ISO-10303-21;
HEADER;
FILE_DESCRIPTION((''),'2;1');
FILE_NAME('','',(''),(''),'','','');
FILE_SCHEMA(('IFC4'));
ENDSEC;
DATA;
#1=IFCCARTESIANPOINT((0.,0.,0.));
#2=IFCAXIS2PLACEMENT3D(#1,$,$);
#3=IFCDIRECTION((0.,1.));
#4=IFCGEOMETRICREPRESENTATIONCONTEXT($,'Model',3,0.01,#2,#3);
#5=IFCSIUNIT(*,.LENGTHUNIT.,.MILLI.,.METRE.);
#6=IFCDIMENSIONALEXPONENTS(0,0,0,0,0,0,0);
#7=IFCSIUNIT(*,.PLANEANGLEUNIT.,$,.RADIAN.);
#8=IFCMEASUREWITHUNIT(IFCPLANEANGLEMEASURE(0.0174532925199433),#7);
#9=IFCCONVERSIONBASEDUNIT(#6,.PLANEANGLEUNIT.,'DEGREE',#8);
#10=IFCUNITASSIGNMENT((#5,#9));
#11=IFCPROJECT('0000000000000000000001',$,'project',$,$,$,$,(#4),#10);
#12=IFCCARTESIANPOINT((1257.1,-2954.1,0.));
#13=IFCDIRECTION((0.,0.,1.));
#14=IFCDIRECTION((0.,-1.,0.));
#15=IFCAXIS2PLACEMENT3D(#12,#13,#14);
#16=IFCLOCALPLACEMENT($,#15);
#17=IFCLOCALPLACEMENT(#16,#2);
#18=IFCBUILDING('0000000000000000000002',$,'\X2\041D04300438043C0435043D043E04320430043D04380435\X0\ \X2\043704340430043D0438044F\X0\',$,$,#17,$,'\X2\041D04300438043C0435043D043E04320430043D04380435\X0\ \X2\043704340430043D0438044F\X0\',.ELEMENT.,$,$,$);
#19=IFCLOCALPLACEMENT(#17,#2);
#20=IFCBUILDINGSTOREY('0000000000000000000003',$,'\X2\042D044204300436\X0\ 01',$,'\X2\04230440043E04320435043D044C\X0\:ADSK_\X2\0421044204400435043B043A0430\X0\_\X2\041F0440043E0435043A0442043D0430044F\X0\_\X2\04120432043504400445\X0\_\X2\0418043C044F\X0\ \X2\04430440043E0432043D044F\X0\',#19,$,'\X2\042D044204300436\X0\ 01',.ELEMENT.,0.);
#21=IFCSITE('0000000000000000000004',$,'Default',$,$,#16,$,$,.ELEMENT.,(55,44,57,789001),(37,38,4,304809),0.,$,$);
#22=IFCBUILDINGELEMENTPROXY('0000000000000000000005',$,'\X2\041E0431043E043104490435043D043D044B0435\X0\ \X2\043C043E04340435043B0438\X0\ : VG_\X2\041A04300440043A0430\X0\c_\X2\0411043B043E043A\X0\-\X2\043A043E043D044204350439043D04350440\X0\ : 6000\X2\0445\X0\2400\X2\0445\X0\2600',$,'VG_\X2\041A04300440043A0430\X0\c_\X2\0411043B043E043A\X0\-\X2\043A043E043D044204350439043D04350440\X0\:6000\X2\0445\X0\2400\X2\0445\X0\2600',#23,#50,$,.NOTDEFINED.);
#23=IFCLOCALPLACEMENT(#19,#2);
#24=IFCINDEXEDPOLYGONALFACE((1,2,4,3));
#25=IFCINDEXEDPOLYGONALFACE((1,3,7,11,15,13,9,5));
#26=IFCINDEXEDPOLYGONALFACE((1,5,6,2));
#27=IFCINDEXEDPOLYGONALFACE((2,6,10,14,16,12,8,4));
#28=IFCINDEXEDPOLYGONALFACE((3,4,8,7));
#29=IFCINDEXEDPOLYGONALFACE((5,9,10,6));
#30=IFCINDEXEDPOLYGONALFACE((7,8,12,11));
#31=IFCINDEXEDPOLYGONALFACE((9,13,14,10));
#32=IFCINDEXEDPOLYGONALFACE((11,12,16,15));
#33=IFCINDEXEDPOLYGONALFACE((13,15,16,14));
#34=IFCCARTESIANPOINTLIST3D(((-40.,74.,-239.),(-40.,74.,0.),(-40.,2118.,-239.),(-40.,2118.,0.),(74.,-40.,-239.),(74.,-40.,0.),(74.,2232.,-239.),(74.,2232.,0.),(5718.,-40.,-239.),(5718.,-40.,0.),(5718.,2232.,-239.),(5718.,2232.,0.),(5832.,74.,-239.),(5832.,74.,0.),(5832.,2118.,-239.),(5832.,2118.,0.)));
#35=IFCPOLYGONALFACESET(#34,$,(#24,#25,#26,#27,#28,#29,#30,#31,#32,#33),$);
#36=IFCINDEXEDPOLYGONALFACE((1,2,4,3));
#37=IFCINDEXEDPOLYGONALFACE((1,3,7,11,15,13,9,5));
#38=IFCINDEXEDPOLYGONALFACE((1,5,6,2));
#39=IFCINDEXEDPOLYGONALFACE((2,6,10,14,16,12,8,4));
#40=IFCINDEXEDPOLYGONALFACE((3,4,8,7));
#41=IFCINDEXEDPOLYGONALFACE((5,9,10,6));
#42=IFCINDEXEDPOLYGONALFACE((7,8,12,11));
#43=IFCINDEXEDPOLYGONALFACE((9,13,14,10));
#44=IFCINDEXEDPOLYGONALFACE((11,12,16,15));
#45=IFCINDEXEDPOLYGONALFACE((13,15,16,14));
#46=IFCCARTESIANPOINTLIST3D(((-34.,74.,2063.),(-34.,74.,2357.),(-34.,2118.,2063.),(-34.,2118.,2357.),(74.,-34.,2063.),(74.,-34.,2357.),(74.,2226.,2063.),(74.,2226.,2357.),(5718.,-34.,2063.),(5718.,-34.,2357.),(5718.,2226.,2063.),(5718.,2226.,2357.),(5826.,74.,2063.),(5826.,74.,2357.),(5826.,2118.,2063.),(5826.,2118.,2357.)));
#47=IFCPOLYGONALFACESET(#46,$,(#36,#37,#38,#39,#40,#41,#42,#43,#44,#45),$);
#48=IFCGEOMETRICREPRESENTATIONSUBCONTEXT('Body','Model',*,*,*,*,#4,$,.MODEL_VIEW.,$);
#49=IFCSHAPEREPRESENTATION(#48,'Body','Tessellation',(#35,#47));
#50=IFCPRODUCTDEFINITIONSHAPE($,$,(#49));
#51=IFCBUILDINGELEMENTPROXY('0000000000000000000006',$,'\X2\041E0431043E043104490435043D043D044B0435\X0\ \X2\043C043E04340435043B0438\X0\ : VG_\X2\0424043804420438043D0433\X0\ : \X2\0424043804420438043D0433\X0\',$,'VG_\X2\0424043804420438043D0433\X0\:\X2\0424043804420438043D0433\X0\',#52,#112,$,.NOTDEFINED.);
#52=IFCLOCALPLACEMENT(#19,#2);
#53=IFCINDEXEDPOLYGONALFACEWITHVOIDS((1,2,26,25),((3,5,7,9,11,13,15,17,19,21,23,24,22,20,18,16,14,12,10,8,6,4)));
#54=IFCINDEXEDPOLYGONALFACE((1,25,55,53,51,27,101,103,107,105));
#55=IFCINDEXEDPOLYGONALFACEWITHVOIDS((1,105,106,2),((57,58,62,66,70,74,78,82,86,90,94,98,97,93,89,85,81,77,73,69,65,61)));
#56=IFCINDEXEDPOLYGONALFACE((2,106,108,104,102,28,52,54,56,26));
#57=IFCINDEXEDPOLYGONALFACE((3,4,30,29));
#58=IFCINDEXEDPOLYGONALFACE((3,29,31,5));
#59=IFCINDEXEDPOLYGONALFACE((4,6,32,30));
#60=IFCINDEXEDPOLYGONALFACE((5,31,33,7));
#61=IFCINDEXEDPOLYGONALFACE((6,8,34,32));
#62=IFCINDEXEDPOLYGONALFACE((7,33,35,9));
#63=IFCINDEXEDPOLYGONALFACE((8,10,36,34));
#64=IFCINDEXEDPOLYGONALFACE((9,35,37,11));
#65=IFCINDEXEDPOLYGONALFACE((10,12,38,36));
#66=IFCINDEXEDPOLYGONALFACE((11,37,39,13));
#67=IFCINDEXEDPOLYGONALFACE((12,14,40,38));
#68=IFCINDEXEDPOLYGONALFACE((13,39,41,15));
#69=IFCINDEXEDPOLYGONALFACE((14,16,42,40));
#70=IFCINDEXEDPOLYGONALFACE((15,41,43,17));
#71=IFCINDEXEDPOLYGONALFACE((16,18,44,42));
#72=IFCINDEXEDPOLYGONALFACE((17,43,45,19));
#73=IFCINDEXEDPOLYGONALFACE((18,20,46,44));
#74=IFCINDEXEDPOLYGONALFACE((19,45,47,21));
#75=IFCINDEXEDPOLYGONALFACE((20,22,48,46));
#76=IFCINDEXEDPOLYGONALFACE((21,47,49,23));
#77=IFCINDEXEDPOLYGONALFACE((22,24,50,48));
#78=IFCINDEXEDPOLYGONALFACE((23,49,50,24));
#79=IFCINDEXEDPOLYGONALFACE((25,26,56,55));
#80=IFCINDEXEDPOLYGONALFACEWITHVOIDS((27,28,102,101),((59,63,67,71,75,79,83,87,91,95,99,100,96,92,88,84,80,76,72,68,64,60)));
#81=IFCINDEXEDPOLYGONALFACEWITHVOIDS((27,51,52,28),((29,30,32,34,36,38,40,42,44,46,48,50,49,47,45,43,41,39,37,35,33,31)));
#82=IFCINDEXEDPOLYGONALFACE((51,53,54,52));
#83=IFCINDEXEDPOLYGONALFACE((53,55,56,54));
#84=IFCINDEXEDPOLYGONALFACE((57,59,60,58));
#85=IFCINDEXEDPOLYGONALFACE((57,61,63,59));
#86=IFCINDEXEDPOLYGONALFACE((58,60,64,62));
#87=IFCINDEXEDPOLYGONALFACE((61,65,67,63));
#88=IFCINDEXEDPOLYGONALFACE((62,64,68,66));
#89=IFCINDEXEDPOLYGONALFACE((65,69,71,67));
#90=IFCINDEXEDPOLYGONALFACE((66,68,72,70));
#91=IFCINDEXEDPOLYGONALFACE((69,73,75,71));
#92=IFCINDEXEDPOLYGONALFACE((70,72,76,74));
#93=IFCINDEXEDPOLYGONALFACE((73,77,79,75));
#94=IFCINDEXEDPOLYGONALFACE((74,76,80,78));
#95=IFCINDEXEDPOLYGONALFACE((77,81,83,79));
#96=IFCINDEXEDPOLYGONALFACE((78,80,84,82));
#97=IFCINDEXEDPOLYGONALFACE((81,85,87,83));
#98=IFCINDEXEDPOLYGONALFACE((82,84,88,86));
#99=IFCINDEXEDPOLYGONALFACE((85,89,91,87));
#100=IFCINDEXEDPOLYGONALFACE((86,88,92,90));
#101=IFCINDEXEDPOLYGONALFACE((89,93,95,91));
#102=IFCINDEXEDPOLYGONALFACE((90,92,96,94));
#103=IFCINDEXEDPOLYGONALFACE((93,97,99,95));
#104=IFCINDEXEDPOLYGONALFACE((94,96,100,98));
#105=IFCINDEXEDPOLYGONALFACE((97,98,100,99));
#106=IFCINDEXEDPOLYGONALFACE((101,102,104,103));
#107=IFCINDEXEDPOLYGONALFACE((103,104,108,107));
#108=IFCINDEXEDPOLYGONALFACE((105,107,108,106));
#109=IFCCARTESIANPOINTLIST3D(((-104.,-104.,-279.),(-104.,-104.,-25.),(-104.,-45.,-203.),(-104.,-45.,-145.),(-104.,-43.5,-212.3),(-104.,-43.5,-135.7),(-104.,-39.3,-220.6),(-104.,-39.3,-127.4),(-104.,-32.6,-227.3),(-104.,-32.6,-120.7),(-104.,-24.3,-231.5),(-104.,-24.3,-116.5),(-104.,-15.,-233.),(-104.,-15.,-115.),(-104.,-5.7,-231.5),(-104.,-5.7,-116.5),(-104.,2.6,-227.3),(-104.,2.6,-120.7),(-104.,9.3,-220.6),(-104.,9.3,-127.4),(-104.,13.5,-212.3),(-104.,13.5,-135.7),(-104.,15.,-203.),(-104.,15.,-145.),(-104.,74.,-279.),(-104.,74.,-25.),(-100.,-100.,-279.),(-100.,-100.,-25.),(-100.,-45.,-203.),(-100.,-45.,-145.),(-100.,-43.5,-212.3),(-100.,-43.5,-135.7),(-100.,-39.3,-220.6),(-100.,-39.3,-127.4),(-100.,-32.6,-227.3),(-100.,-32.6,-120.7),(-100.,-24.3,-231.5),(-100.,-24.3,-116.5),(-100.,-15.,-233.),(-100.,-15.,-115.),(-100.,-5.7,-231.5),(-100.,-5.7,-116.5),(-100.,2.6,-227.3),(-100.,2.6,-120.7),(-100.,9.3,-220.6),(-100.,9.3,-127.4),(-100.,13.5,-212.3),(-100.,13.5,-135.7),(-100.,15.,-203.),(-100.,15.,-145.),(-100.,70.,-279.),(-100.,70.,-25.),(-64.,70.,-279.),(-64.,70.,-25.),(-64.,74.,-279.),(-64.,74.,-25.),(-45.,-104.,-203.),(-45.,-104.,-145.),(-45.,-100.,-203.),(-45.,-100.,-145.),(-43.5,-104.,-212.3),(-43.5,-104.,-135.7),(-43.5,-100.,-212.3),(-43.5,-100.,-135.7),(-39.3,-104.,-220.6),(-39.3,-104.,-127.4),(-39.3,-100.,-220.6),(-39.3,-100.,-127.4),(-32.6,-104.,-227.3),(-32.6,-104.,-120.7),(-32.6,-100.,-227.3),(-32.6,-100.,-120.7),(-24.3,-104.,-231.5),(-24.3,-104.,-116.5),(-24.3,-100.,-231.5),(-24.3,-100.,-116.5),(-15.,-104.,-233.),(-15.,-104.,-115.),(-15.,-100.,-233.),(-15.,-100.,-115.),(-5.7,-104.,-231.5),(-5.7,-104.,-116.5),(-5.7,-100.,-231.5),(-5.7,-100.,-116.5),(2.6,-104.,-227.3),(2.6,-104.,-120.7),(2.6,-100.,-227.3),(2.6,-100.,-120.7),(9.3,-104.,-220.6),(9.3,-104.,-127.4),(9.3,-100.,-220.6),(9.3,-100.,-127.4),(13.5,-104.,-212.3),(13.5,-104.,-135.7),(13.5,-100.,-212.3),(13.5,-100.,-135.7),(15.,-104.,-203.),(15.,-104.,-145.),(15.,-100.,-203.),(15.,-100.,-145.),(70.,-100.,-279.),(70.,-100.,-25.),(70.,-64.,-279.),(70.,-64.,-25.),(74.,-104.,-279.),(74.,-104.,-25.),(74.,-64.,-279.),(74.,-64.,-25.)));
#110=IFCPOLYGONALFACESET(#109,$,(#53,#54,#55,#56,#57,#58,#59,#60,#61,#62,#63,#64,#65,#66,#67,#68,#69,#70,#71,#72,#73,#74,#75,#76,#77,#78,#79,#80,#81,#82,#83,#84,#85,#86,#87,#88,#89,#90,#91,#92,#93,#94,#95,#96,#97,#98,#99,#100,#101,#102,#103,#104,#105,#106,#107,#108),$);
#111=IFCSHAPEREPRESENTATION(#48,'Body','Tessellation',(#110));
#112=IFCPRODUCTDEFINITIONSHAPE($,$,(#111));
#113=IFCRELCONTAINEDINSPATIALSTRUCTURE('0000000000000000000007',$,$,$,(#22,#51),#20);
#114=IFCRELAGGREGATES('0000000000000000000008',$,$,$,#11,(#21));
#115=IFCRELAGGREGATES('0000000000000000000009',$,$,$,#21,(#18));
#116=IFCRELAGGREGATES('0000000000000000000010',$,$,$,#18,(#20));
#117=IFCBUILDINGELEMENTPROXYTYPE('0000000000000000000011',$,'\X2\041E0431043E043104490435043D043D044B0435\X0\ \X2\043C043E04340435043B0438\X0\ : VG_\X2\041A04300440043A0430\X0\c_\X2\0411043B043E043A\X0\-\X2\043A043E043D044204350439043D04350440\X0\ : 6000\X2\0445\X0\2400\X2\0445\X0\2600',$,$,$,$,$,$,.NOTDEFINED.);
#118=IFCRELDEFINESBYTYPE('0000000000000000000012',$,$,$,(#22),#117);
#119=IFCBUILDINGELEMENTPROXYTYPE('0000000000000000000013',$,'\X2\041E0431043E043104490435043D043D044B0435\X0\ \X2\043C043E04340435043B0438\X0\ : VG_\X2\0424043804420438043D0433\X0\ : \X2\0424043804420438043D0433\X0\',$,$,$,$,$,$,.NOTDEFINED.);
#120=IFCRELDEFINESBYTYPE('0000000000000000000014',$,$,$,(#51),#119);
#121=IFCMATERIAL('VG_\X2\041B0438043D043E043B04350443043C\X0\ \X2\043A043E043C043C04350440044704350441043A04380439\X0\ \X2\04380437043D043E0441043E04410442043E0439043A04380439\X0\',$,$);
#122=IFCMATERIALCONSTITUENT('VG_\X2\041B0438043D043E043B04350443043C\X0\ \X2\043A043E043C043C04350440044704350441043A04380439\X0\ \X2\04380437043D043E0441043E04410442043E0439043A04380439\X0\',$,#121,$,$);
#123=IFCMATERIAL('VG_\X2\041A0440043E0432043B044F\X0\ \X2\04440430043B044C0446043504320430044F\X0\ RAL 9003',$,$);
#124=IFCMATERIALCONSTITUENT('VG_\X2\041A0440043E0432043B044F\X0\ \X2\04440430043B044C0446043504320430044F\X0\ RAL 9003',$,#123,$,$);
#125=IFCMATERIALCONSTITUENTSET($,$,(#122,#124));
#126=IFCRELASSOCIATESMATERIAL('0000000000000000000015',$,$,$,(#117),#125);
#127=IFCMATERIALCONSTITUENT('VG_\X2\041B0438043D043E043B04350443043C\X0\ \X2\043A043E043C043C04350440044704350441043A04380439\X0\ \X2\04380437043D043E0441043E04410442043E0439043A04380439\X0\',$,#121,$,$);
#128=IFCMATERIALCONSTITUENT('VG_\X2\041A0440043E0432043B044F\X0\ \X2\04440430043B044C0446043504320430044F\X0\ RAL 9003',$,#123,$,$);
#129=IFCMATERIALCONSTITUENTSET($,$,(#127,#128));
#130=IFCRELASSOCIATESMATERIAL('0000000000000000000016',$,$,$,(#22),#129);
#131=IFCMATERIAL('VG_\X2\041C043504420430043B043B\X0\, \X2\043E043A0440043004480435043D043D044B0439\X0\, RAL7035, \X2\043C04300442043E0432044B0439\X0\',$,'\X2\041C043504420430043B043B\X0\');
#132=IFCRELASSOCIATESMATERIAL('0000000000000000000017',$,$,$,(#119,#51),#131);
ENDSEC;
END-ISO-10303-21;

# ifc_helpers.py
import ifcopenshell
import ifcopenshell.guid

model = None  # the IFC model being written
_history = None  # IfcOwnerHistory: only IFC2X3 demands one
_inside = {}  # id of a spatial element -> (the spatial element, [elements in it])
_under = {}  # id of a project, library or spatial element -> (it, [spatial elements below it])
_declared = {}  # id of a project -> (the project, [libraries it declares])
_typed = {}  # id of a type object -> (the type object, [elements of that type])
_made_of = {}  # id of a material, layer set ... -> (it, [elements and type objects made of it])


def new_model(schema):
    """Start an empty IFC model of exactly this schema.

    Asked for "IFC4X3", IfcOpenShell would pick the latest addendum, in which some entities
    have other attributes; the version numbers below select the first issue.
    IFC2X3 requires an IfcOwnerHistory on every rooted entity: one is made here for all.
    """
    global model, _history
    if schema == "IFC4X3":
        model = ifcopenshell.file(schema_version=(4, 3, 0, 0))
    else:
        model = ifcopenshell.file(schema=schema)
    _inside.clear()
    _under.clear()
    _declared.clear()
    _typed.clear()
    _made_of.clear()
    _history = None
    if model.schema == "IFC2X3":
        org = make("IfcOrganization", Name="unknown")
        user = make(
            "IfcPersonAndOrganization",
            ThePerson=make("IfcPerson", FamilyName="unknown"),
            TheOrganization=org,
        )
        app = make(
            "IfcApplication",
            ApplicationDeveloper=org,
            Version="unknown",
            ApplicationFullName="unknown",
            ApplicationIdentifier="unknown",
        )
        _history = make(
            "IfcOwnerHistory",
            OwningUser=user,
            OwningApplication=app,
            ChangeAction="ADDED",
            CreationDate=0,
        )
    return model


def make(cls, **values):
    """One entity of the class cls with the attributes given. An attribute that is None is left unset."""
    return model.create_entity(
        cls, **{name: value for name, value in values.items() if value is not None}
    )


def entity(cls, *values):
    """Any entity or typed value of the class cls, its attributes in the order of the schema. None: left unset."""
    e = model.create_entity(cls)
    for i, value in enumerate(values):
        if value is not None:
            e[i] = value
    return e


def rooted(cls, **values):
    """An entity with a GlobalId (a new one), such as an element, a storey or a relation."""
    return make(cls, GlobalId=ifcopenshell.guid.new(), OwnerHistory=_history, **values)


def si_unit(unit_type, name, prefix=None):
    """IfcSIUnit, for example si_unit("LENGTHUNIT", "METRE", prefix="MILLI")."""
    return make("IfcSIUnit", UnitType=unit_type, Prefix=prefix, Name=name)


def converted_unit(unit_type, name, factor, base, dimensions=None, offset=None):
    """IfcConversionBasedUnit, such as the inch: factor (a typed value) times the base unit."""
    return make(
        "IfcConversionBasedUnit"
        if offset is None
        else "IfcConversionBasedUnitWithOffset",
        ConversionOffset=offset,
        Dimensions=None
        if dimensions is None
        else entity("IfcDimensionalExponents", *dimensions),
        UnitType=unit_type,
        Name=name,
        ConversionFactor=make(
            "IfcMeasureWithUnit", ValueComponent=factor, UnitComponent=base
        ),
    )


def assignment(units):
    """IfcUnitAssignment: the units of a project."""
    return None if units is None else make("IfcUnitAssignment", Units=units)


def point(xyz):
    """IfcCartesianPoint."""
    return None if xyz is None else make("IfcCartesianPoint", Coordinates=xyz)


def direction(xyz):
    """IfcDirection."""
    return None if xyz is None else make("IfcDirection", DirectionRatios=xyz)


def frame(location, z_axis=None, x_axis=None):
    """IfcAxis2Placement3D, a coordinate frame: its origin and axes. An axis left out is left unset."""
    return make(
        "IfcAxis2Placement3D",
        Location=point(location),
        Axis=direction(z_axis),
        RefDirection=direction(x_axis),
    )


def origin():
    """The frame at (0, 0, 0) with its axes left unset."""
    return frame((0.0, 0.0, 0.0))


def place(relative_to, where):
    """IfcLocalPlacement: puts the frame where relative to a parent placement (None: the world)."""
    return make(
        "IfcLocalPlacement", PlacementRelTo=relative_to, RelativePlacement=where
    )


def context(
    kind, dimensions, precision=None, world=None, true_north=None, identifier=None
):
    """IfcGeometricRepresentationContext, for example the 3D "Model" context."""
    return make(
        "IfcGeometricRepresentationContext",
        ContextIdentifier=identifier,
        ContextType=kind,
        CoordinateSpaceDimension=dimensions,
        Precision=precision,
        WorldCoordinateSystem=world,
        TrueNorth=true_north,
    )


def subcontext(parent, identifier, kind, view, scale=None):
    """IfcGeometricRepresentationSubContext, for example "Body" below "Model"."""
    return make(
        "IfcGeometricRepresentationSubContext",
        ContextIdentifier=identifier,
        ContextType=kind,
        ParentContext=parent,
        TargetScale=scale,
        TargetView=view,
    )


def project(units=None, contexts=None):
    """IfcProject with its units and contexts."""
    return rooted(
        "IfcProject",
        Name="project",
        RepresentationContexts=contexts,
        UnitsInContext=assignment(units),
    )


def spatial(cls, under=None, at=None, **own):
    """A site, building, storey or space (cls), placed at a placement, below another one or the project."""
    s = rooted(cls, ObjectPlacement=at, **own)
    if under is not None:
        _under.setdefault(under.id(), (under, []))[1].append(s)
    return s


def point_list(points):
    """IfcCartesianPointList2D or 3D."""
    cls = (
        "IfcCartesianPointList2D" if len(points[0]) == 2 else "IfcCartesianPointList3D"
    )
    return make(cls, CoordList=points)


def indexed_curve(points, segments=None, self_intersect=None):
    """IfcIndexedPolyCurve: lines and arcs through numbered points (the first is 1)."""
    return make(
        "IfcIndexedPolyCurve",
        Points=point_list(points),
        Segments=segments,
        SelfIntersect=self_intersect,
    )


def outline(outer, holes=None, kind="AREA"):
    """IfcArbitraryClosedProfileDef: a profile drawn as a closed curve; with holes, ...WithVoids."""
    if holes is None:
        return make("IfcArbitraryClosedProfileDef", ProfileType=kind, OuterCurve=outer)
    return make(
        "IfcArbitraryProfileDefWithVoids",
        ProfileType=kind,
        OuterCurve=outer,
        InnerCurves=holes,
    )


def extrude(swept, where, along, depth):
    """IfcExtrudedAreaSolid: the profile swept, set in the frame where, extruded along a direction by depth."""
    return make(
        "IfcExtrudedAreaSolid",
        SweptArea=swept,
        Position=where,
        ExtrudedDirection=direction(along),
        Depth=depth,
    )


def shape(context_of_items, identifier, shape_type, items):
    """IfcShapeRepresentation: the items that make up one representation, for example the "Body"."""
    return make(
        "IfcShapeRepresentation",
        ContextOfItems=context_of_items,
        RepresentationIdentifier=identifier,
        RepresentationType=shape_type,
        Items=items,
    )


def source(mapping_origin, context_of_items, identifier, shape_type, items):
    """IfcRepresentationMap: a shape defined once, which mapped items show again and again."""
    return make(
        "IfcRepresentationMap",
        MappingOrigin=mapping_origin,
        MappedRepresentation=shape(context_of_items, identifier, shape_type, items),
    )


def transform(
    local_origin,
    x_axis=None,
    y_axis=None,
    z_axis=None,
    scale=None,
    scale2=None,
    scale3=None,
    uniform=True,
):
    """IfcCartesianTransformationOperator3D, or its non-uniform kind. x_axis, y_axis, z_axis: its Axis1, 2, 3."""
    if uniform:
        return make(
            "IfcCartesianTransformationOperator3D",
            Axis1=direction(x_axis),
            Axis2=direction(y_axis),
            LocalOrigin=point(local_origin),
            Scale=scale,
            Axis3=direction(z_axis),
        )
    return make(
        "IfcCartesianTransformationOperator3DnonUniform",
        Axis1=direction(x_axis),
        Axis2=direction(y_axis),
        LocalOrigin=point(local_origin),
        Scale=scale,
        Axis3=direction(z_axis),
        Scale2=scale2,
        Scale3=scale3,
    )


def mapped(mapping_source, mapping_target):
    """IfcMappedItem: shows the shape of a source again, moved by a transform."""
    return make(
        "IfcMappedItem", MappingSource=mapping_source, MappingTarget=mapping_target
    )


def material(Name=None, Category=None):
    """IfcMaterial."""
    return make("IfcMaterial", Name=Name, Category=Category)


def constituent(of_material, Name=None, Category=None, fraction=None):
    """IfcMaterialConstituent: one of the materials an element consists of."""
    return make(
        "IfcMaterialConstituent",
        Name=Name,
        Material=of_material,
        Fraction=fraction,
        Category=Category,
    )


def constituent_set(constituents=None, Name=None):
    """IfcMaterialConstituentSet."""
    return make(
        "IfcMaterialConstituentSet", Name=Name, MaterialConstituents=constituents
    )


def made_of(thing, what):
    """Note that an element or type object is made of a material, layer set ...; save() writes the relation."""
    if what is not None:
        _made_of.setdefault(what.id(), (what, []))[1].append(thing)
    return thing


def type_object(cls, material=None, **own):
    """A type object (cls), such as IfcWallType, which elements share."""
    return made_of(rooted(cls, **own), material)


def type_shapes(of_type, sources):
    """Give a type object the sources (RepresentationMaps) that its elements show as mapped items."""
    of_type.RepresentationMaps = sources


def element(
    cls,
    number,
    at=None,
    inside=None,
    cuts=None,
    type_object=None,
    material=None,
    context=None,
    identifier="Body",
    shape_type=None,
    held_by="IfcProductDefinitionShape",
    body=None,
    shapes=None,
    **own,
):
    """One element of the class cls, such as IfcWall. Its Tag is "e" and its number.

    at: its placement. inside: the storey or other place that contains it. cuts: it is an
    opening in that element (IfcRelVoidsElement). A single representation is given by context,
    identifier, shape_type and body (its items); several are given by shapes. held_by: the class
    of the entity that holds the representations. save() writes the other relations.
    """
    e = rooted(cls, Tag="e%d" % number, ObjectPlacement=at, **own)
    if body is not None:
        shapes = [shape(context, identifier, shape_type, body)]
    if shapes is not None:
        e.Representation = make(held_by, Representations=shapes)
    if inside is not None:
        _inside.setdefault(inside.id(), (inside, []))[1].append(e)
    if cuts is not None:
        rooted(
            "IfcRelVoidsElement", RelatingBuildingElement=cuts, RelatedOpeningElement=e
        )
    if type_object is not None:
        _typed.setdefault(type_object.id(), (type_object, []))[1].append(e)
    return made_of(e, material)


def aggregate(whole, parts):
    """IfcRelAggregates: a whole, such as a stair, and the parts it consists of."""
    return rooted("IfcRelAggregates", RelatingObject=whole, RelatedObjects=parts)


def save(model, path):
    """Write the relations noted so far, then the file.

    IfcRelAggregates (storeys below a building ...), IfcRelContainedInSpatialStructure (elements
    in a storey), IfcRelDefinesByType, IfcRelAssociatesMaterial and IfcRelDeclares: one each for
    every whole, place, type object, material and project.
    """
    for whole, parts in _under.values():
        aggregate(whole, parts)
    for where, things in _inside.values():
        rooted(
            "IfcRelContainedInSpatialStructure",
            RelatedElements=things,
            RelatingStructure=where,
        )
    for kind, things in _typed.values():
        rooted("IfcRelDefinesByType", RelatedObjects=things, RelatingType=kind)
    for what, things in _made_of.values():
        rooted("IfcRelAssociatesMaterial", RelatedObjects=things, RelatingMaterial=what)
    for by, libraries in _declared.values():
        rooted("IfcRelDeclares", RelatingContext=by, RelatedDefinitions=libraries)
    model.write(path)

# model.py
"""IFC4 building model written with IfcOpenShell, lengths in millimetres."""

from ifc_helpers import new_model, entity, si_unit, converted_unit, direction, frame, origin, place, context, subcontext, project, spatial, indexed_curve, outline, extrude, source, transform, mapped, material, constituent, constituent_set, type_object, type_shapes, element, save


model = new_model("IFC4")

# Units and contexts
model_context = context("Model", 3, precision=0.01, world=origin(), true_north=direction((0.0, 1.0)))
body_context = subcontext(model_context, "Body", "Model", "MODEL_VIEW")
ifc_project = project(units=[si_unit("LENGTHUNIT", "METRE", prefix="MILLI"), converted_unit("PLANEANGLEUNIT", "DEGREE", entity("IfcPlaneAngleMeasure", 0.0174532925199433), si_unit("PLANEANGLEUNIT", "RADIAN"), dimensions=[0, 0, 0, 0, 0, 0, 0])], contexts=[model_context])

# Site, building, storey
site_placement = place(None, frame((1257.1, -2954.1, 0.0), z_axis=(0.0, 0.0, 1.0), x_axis=(0.0, -1.0, 0.0)))
site = spatial("IfcSite", under=ifc_project, at=site_placement, Name="Default", CompositionType="ELEMENT", RefLatitude=(55, 44, 57, 789001), RefLongitude=(37, 38, 4, 304809), RefElevation=0.0)
building_placement = place(site_placement, origin())
building = spatial("IfcBuilding", under=site, at=building_placement, Name="Наименование здания", LongName="Наименование здания", CompositionType="ELEMENT")
storey_placement = place(building_placement, origin())
storey = spatial("IfcBuildingStorey", under=building, at=storey_placement, Name="Этаж 01", ObjectType="Уровень:ADSK_Стрелка_Проектная_Вверх_Имя уровня", LongName="Этаж 01", CompositionType="ELEMENT", Elevation=0.0)

# Shared definitions
ifc_material_1 = material(Name="VG_Линолеум коммерческий износостойкий")

# Building element proxy
ifc_constituent_1 = constituent(ifc_material_1, Name="VG_Линолеум коммерческий износостойкий")
ifc_material_2 = material(Name="VG_Кровля фальцевая RAL 9003")
ifc_constituent_2 = constituent(ifc_material_2, Name="VG_Кровля фальцевая RAL 9003")
ifc_constituent_set_1 = constituent_set(constituents=[ifc_constituent_1, ifc_constituent_2])
ifc_constituent_3 = constituent(ifc_material_1, Name="VG_Линолеум коммерческий износостойкий")
ifc_constituent_4 = constituent(ifc_material_2, Name="VG_Кровля фальцевая RAL 9003")
ifc_constituent_set_2 = constituent_set(constituents=[ifc_constituent_3, ifc_constituent_4])
building_element_proxy_type_1 = type_object("IfcBuildingElementProxyType", Name="Обобщенные модели : VG_Каркаc_Блок-контейнер : 6000х2400х2600", PredefinedType="NOTDEFINED", material=ifc_constituent_set_2)
shared_shape_1 = source(origin(), body_context, "Body", "SweptSolid", [
    extrude(outline(indexed_curve([(-2822.0, -1136.0), (2822.0, -1136.0), (2936.0, -1022.0), (2936.0, 1022.0), (2822.0, 1136.0), (-2822.0, 1136.0), (-2936.0, 1022.0), (-2936.0, -1022.0), (-2822.0, -1136.0)], self_intersect=False)), frame((2896.0, 1096.0, -239.0), z_axis=(0.0, 0.0, 1.0), x_axis=(-1.0, 0.0, 0.0)), (0.0, 0.0, 1.0), 239.0),
    extrude(outline(indexed_curve([(-2822.0, -1130.0), (2822.0, -1130.0), (2930.0, -1022.0), (2930.0, 1022.0), (2822.0, 1130.0), (-2822.0, 1130.0), (-2930.0, 1022.0), (-2930.0, -1022.0), (-2822.0, -1130.0)], self_intersect=False)), frame((2896.0, 1096.0, 2063.0), z_axis=(0.0, 0.0, 1.0), x_axis=(-1.0, 0.0, 0.0)), (0.0, 0.0, 1.0), 294.0),
])
type_shapes(building_element_proxy_type_1, [shared_shape_1])
proxy_1_placement = place(storey_placement, origin())
element("IfcBuildingElementProxy", 1, at=proxy_1_placement, inside=storey, type_object=building_element_proxy_type_1, material=ifc_constituent_set_1, Name="Обобщенные модели : VG_Каркаc_Блок-контейнер : 6000х2400х2600", ObjectType="VG_Каркаc_Блок-контейнер:6000х2400х2600", PredefinedType="NOTDEFINED", context=body_context, shape_type="MappedRepresentation", body=[
    mapped(shared_shape_1, transform((0.0, 0.0, 0.0), scale=1.0)),
])

# Building element proxy, openings
ifc_material_3 = material(Name="VG_Металл, окрашенный, RAL7035, матовый", Category="Металл")
building_element_proxy_type_2 = type_object("IfcBuildingElementProxyType", Name="Обобщенные модели : VG_Фитинг : Фитинг", PredefinedType="NOTDEFINED", material=ifc_material_3)
shared_shape_2 = source(origin(), body_context, "Body", "SweptSolid", [
    extrude(outline(indexed_curve([(-79.2, -79.2), (98.8, -79.2), (98.8, -39.2), (94.8, -39.2), (94.8, -75.2), (-75.2, -75.2), (-75.2, 94.8), (-39.2, 94.8), (-39.2, 98.8), (-79.2, 98.8), (-79.2, -79.2)], self_intersect=False)), frame((-9.8, -9.8, -279.0)), (0.0, 0.0, 1.0), 254.0),
])
type_shapes(building_element_proxy_type_2, [shared_shape_2])
proxy_2_placement = place(storey_placement, frame((-15.0, -15.0, 0.0)))
proxy_2 = element("IfcBuildingElementProxy", 2, at=proxy_2_placement, inside=storey, type_object=building_element_proxy_type_2, material=ifc_material_3, Name="Обобщенные модели : VG_Фитинг : Фитинг", ObjectType="VG_Фитинг:Фитинг", PredefinedType="NOTDEFINED", context=body_context, shape_type="MappedRepresentation", body=[
    mapped(shared_shape_2, transform((0.0, 0.0, 0.0), scale=1.0)),
])
opening_1_placement = place(storey_placement, frame((-15.0, -15.0, 0.0)))
element("IfcOpeningElement", 3, at=opening_1_placement, cuts=proxy_2, PredefinedType="OPENING", context=body_context, shape_type="SweptSolid", body=[
    extrude(outline(indexed_curve([(-30.0, -29.0), (-28.5, -38.3), (-24.3, -46.6), (-17.6, -53.3), (-9.3, -57.5), (0.0, -59.0), (9.3, -57.5), (17.6, -53.3), (24.3, -46.6), (28.5, -38.3), (30.0, -29.0), (30.0, 29.0), (28.5, 38.3), (24.3, 46.6), (17.6, 53.3), (9.3, 57.5), (0.0, 59.0), (-9.3, 57.5), (-17.6, 53.3), (-24.3, 46.6), (-28.5, 38.3), (-30.0, 29.0), (-30.0, -29.0)], self_intersect=False)), frame((0.0, -89.0, -174.0), z_axis=(0.0, 1.0, 0.0), x_axis=(1.0, 0.0, 0.0)), (0.0, 0.0, 1.0), 4.0),
])
opening_2_placement = place(storey_placement, frame((-15.0, -15.0, 0.0)))
element("IfcOpeningElement", 4, at=opening_2_placement, cuts=proxy_2, PredefinedType="OPENING", context=body_context, shape_type="SweptSolid", body=[
    extrude(outline(indexed_curve([(-30.0, -29.0), (-28.5, -38.3), (-24.3, -46.6), (-17.6, -53.3), (-9.3, -57.5), (0.0, -59.0), (9.3, -57.5), (17.6, -53.3), (24.3, -46.6), (28.5, -38.3), (30.0, -29.0), (30.0, 29.0), (28.5, 38.3), (24.3, 46.6), (17.6, 53.3), (9.3, 57.5), (0.0, 59.0), (-9.3, 57.5), (-17.6, 53.3), (-24.3, 46.6), (-28.5, 38.3), (-30.0, 29.0), (-30.0, -29.0)], self_intersect=False)), frame((-89.0, 0.0, -174.0), z_axis=(1.0, 0.0, 0.0), x_axis=(0.0, -1.0, 0.0)), (0.0, 0.0, 1.0), 4.0),
])

save(model, "model.ifc")
